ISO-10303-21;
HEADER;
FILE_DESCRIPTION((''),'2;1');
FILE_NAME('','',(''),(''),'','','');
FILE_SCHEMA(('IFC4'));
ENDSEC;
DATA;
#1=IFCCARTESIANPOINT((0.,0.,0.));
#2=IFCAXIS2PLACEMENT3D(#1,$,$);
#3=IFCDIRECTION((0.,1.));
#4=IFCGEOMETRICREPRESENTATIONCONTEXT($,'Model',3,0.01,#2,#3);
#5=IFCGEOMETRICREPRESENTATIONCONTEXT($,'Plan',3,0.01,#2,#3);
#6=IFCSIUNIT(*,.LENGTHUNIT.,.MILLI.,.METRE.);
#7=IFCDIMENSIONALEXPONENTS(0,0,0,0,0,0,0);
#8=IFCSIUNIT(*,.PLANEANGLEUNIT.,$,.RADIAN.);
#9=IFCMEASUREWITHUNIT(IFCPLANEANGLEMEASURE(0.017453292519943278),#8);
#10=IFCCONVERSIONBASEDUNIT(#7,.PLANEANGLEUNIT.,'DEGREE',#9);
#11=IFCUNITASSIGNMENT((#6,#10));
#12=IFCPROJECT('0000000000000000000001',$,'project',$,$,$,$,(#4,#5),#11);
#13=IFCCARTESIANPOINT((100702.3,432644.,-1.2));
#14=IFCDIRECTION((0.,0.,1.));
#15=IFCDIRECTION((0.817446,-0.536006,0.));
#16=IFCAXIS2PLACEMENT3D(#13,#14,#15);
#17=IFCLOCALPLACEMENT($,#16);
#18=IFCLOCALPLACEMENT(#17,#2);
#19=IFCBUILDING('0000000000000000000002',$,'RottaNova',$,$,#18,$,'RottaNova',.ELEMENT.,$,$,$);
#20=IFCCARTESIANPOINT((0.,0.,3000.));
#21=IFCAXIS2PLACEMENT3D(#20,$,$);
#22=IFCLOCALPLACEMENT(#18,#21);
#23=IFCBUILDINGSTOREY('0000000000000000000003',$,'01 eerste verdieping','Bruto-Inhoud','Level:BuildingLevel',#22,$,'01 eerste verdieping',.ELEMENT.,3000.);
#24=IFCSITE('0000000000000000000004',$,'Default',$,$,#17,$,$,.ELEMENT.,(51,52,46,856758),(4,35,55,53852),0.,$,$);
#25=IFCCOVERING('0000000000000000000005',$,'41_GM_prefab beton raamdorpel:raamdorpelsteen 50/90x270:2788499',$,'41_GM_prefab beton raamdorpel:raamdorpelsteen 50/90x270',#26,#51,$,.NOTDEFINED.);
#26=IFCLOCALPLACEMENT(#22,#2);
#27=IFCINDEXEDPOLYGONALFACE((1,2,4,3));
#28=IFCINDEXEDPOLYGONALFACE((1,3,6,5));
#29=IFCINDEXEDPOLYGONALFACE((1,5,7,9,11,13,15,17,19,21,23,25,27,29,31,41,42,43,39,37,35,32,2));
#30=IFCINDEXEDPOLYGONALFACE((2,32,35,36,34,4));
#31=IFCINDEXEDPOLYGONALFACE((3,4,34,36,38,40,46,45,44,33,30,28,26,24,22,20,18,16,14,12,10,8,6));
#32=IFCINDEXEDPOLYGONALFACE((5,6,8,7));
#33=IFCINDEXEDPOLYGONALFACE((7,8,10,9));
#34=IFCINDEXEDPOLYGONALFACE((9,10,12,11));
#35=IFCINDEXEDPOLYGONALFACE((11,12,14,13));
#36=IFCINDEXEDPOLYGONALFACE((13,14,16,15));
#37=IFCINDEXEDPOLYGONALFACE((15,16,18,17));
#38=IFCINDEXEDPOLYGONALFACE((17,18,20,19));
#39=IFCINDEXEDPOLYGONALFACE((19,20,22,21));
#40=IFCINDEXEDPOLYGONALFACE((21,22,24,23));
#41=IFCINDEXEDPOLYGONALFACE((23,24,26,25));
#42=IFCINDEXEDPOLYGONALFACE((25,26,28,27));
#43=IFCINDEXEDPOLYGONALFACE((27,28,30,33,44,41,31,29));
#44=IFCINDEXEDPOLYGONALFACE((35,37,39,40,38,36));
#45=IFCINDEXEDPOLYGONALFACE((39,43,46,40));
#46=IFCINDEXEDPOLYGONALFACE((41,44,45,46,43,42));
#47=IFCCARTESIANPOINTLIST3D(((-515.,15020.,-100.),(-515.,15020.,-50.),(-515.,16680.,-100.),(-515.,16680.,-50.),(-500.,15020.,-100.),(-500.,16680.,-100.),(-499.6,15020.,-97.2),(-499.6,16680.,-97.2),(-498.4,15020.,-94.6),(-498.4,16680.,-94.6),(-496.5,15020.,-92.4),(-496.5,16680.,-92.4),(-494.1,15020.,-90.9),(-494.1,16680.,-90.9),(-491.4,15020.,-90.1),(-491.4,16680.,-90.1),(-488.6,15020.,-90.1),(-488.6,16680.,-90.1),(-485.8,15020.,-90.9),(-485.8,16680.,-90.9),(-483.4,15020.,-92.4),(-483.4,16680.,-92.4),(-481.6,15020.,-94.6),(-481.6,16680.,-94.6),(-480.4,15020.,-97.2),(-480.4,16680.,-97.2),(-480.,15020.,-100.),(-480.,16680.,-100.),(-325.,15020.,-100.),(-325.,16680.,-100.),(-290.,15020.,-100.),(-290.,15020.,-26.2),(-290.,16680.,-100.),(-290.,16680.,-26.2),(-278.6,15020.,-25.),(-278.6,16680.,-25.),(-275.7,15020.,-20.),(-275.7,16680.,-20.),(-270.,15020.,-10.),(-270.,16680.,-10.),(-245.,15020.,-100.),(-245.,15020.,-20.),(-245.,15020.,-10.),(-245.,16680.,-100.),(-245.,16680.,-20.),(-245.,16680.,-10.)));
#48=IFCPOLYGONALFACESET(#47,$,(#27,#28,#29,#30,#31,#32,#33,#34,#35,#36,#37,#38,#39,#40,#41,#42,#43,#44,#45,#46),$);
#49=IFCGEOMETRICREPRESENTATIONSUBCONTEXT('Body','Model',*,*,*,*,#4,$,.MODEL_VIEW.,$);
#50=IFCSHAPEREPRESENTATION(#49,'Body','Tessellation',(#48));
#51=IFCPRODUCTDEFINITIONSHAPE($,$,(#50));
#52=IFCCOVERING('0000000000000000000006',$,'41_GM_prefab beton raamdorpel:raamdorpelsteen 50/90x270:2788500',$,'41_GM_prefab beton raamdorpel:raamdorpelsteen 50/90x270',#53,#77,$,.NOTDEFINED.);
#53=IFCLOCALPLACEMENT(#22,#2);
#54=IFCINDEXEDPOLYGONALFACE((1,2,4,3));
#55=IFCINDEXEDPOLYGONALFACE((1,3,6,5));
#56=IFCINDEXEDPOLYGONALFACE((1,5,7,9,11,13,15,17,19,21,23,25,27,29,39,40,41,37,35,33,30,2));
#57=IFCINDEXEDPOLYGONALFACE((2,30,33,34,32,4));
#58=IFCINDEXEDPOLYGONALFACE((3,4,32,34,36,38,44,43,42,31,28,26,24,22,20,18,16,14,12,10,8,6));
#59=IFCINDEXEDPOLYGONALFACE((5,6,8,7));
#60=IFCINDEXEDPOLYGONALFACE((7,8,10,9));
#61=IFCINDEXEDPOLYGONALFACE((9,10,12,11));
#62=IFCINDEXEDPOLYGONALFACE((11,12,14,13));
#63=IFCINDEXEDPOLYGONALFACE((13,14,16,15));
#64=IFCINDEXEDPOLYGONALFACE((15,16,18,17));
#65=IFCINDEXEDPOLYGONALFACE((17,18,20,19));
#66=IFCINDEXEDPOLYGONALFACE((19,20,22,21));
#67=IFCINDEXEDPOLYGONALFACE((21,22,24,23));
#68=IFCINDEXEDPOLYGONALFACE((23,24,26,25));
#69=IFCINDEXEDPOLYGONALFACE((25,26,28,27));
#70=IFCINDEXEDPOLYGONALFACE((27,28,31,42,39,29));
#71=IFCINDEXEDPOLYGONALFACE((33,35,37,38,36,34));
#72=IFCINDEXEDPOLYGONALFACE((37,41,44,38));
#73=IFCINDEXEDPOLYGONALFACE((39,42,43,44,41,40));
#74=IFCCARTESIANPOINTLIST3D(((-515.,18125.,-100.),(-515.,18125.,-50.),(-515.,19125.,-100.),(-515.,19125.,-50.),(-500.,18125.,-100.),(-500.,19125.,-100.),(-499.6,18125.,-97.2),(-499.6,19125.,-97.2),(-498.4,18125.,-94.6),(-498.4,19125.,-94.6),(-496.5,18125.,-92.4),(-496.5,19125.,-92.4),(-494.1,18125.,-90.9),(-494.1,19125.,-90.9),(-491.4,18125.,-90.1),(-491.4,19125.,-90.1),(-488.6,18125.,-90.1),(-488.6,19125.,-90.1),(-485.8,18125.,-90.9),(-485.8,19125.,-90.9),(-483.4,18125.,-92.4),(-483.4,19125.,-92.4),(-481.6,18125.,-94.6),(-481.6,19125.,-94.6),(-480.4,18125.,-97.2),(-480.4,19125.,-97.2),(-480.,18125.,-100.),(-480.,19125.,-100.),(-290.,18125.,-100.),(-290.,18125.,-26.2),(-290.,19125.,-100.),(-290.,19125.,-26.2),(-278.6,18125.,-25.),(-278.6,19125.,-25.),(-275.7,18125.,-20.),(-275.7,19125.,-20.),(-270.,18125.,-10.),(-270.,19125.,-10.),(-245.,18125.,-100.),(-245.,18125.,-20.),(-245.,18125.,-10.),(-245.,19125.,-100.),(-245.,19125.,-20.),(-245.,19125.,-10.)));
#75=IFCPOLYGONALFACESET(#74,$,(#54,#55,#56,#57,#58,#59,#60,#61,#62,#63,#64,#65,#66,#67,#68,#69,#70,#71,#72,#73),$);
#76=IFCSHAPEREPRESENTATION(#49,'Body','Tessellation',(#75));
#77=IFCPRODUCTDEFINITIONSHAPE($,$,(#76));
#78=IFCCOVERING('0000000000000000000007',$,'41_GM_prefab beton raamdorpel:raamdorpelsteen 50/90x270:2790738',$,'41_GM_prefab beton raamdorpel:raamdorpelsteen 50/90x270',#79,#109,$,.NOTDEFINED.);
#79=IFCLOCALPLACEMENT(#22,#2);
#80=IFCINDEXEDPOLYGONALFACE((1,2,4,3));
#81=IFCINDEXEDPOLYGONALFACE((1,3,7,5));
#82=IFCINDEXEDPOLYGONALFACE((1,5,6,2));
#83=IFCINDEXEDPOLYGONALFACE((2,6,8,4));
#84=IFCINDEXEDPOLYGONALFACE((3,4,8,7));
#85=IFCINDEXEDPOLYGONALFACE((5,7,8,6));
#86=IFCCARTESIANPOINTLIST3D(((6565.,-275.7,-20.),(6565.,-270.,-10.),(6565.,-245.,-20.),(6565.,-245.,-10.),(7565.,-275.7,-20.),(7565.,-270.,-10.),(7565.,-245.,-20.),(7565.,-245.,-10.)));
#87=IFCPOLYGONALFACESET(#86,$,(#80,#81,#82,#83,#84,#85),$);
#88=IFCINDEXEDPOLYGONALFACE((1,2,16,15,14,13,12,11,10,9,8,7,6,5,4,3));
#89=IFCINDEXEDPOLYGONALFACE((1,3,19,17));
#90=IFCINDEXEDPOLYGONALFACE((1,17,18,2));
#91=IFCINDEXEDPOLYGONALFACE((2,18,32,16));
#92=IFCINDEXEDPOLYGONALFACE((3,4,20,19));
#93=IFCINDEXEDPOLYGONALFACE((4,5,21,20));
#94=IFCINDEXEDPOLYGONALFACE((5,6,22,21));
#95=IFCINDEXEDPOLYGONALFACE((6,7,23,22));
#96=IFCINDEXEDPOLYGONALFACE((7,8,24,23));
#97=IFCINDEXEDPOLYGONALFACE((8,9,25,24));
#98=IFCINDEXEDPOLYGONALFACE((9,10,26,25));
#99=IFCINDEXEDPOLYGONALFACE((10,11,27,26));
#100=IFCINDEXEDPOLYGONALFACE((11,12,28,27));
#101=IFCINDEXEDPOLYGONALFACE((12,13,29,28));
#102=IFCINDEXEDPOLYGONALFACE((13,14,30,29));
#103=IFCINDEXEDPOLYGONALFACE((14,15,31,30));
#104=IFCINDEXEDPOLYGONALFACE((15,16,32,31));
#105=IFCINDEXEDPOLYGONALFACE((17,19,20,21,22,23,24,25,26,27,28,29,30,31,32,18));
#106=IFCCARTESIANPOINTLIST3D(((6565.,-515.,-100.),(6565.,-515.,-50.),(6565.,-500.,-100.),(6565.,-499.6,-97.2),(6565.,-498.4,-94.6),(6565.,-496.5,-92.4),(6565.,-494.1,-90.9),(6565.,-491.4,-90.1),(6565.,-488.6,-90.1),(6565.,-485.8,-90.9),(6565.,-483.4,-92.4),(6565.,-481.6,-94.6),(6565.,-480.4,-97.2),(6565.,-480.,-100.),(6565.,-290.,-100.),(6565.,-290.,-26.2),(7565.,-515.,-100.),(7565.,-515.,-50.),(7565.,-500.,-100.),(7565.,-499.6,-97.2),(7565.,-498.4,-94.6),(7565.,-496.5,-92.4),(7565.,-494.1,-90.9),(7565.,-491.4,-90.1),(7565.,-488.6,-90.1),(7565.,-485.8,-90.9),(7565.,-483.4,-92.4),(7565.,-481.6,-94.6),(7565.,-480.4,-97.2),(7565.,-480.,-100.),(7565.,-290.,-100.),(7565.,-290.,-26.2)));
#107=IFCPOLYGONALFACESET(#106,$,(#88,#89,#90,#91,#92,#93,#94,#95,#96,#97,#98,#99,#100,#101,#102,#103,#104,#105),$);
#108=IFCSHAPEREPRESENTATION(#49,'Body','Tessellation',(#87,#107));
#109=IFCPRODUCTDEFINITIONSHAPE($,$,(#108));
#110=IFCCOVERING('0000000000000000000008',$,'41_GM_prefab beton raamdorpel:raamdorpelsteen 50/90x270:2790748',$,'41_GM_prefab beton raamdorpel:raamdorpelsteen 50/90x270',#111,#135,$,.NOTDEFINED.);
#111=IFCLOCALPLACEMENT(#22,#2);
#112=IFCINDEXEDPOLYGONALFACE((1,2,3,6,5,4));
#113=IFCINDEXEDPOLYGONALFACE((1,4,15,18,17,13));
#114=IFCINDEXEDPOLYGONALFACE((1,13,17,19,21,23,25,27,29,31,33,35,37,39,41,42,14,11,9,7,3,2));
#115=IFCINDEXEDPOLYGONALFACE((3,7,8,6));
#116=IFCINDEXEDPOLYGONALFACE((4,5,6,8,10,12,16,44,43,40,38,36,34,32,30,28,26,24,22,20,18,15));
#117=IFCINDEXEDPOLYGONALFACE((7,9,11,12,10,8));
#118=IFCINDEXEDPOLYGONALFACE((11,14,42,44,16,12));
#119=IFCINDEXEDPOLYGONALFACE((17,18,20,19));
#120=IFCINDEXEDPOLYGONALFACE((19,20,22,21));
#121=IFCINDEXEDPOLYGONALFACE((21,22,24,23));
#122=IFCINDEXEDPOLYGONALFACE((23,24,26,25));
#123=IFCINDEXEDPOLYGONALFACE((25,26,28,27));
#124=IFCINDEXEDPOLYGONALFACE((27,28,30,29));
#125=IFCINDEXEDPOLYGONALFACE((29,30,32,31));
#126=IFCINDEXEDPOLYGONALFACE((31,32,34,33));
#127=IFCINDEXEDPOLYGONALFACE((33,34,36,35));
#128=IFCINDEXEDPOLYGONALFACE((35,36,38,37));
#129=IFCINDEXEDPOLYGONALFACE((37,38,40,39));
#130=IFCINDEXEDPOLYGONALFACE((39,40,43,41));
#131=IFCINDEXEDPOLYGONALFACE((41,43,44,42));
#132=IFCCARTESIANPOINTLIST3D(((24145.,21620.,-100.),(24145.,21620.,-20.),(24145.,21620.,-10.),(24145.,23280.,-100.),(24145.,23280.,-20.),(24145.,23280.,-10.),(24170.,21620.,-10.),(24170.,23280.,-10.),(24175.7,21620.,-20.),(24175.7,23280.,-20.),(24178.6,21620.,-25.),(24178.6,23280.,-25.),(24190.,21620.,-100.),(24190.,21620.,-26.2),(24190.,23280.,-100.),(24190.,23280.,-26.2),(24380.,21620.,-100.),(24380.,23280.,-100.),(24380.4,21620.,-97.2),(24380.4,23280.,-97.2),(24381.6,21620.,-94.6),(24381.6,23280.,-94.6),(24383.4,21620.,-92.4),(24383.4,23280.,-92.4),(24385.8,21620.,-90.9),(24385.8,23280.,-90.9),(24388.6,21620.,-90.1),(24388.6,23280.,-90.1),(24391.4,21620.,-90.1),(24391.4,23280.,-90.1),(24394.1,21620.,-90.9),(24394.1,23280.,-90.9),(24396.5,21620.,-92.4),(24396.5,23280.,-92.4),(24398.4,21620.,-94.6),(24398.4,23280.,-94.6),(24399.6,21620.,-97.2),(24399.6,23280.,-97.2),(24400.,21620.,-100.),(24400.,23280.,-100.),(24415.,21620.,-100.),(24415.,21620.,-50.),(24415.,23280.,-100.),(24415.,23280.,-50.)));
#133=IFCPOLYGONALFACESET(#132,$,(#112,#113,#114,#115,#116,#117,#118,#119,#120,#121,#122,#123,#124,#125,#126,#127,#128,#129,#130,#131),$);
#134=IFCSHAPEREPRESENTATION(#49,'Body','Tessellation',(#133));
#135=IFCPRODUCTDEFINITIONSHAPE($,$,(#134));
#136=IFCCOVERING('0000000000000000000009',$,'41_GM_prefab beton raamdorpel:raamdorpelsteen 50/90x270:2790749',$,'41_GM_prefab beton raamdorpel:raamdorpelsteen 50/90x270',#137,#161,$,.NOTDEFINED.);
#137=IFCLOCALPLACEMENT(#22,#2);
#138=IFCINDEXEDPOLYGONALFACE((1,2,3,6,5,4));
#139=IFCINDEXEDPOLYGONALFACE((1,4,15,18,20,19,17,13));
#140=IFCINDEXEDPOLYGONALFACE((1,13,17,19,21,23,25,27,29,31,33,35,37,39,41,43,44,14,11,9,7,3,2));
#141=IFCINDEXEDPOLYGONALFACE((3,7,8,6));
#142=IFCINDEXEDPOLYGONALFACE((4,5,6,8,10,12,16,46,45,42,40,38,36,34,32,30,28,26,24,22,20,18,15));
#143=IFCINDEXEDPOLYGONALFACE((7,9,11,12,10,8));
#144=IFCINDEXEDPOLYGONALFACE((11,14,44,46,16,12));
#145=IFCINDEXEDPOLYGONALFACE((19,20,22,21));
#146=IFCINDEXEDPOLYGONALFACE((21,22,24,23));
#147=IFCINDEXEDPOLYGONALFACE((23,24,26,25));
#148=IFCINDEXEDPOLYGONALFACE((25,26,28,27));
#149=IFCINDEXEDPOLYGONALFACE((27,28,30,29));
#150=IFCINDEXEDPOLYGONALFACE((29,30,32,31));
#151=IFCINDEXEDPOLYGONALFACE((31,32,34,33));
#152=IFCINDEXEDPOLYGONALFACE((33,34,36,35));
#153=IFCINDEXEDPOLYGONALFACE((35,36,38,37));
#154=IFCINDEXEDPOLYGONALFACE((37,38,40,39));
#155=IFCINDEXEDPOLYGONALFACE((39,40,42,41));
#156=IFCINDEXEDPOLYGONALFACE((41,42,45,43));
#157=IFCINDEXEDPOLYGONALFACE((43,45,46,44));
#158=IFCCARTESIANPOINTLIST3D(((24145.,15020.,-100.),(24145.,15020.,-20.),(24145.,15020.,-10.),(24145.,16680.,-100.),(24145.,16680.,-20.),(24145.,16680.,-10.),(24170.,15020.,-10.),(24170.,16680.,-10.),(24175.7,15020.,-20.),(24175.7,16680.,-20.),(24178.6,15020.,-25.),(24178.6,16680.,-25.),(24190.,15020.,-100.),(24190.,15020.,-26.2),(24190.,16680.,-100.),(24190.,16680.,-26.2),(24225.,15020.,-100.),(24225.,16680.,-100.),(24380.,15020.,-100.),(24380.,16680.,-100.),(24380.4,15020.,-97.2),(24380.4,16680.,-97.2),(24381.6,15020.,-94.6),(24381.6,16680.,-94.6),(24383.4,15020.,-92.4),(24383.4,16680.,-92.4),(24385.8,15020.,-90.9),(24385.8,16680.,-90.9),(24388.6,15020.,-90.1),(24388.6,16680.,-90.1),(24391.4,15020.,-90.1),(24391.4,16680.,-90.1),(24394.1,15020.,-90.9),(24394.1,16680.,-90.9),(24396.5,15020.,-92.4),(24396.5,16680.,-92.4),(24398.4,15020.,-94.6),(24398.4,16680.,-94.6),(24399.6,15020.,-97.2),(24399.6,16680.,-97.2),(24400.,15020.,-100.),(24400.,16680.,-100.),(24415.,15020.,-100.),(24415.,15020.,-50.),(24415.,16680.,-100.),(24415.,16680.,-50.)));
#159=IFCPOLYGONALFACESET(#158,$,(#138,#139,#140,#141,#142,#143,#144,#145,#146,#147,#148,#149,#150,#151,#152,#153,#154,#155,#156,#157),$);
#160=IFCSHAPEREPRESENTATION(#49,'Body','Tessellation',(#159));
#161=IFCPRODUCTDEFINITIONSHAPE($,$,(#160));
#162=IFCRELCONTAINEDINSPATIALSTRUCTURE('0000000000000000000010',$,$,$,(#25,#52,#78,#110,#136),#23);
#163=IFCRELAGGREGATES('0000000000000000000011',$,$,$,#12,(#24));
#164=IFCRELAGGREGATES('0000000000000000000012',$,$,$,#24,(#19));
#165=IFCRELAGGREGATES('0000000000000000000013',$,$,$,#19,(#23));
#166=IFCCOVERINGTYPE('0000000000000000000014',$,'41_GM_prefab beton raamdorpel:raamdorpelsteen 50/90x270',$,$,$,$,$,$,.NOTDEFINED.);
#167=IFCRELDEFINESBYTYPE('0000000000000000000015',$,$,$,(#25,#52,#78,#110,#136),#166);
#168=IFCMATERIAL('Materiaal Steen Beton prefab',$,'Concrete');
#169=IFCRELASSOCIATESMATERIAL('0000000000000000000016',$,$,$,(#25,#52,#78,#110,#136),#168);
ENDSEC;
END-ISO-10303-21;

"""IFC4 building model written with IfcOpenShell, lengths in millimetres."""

from ifc_helpers import new_model, entity, si_unit, converted_unit, direction, frame, origin, place, context, subcontext, project, spatial, line, arc, indexed_curve, outline, extrude, material, type_object, element, save


model = new_model("IFC4")

# Units and contexts
model_context = context("Model", 3, precision=0.01, world=origin(), true_north=direction((0.0, 1.0)))
plan_context = context("Plan", 3, precision=0.01, world=origin(), true_north=direction((0.0, 1.0)))
body_context = subcontext(model_context, "Body", "Model", "MODEL_VIEW")
ifc_project = project(units=[si_unit("LENGTHUNIT", "METRE", prefix="MILLI"), converted_unit("PLANEANGLEUNIT", "DEGREE", entity("IfcPlaneAngleMeasure", 0.017453292519943278), si_unit("PLANEANGLEUNIT", "RADIAN"), dimensions=[0, 0, 0, 0, 0, 0, 0])], contexts=[model_context, plan_context])

# Site, building, storey
site_placement = place(None, frame((100702.3, 432644.0, -1.2), z_axis=(0.0, 0.0, 1.0), x_axis=(0.817446, -0.536006, 0.0)))
site = spatial("IfcSite", under=ifc_project, at=site_placement, Name="Default", CompositionType="ELEMENT", RefLatitude=(51, 52, 46, 856758), RefLongitude=(4, 35, 55, 53852), RefElevation=0.0)
building_placement = place(site_placement, origin())
building = spatial("IfcBuilding", under=site, at=building_placement, Name="RottaNova", LongName="RottaNova", CompositionType="ELEMENT")
storey_placement = place(building_placement, frame((0.0, 0.0, 3000.0)))
storey = spatial("IfcBuildingStorey", under=building, at=storey_placement, Name="01 eerste verdieping", Description="Bruto-Inhoud", ObjectType="Level:BuildingLevel", LongName="01 eerste verdieping", CompositionType="ELEMENT", Elevation=3000.0)

# Coverings
ifc_material_1 = material(Name="Materiaal Steen Beton prefab", Category="Concrete")
covering_type_1 = type_object("IfcCoveringType", Name="41_GM_prefab beton raamdorpel:raamdorpelsteen 50/90x270", PredefinedType="NOTDEFINED")
covering_1_placement = place(storey_placement, origin())
element("IfcCovering", 1, at=covering_1_placement, inside=storey, type_object=covering_type_1, material=ifc_material_1, Name="41_GM_prefab beton raamdorpel:raamdorpelsteen 50/90x270:2788499", ObjectType="41_GM_prefab beton raamdorpel:raamdorpelsteen 50/90x270", PredefinedType="NOTDEFINED", context=body_context, shape_type="SweptSolid", body=[
    extrude(outline(indexed_curve([(74.2, -48.6), (99.2, -48.6), (99.2, -38.6), (99.2, 41.4), (54.2, 41.4), (19.2, 41.4), (-135.8, 41.4), (-145.8, 31.4), (-155.8, 41.4), (-170.8, 41.4), (-170.8, -8.6), (54.2, -32.4), (65.5, -33.6), (68.4, -38.6)], segments=[line(1, 2, 3, 4, 5, 6, 7), arc(7, 8, 9), line(9, 10, 11, 12, 13, 14, 1)], self_intersect=False)), frame((-344.2, 15020.0, -58.6), z_axis=(0.0, 1.0, 0.0), x_axis=(1.0, 0.0, 0.0)), (0.0, 0.0, 1.0), 1660.0),
])
covering_2_placement = place(storey_placement, origin())
element("IfcCovering", 2, at=covering_2_placement, inside=storey, type_object=covering_type_1, material=ifc_material_1, Name="41_GM_prefab beton raamdorpel:raamdorpelsteen 50/90x270:2788500", ObjectType="41_GM_prefab beton raamdorpel:raamdorpelsteen 50/90x270", PredefinedType="NOTDEFINED", context=body_context, shape_type="SweptSolid", body=[
    extrude(outline(indexed_curve([(75.8, -45.1), (100.8, -45.1), (100.8, -35.1), (100.8, 44.9), (55.8, 44.9), (-134.2, 44.9), (-144.2, 34.9), (-154.2, 44.9), (-169.2, 44.9), (-169.2, -5.1), (55.8, -28.9), (67.1, -30.1), (70.0, -35.1)], segments=[line(1, 2, 3, 4, 5, 6), arc(6, 7, 8), line(8, 9, 10, 11, 12, 13, 1)], self_intersect=False)), frame((-345.8, 18125.0, -55.1), z_axis=(0.0, 1.0, 0.0), x_axis=(1.0, 0.0, 0.0)), (0.0, 0.0, 1.0), 1000.0),
])
covering_3_placement = place(storey_placement, origin())
element("IfcCovering", 3, at=covering_3_placement, inside=storey, type_object=covering_type_1, material=ifc_material_1, Name="41_GM_prefab beton raamdorpel:raamdorpelsteen 50/90x270:2790738", ObjectType="41_GM_prefab beton raamdorpel:raamdorpelsteen 50/90x270", PredefinedType="NOTDEFINED", context=body_context, shape_type="SweptSolid", body=[
    extrude(outline(indexed_curve([(1.2, -12.1), (12.7, -12.1), (-2.6, 14.6), (-11.3, 9.6), (1.2, -12.1)], self_intersect=False)), frame((6565.0, -258.9, -15.0), z_axis=(1.0, 0.0, 0.0), x_axis=(0.0, -0.5, -0.866025)), (0.0, 0.0, 1.0), 1000.0),
    extrude(outline(indexed_curve([(-48.3, -20.6), (141.7, -20.6), (141.7, 53.2), (-83.3, 29.4), (-83.3, -20.6), (-68.3, -20.6), (-58.3, -10.6)], segments=[line(1, 2, 3, 4, 5, 6), arc(6, 7, 1)], self_intersect=False)), frame((6565.0, -431.7, -79.4), z_axis=(1.0, 0.0, 0.0), x_axis=(0.0, 1.0, 0.0)), (0.0, 0.0, 1.0), 1000.0),
])
covering_4_placement = place(storey_placement, origin())
element("IfcCovering", 4, at=covering_4_placement, inside=storey, type_object=covering_type_1, material=ifc_material_1, Name="41_GM_prefab beton raamdorpel:raamdorpelsteen 50/90x270:2790748", ObjectType="41_GM_prefab beton raamdorpel:raamdorpelsteen 50/90x270", PredefinedType="NOTDEFINED", context=body_context, shape_type="SweptSolid", body=[
    extrude(outline(indexed_curve([(-77.0, -43.1), (-89.5, -64.7), (-80.8, -69.7), (-11.5, -109.7), (11.0, -70.7), (106.0, 93.8), (102.3, 107.5), (116.0, 111.1), (123.5, 124.1), (80.2, 149.1), (-52.9, -33.8), (-59.6, -43.1), (-65.4, -43.1)], segments=[line(1, 2, 3, 4, 5, 6), arc(6, 7, 8), line(8, 9, 10, 11, 12, 13, 1)], self_intersect=False)), frame((24245.8, 21620.0, -55.1), z_axis=(0.0, -1.0, 0.0), x_axis=(0.5, 0.0, -0.866025)), (0.0, 0.0, -1.0), 1660.0),
])
covering_5_placement = place(storey_placement, origin())
element("IfcCovering", 5, at=covering_5_placement, inside=storey, type_object=covering_type_1, material=ifc_material_1, Name="41_GM_prefab beton raamdorpel:raamdorpelsteen 50/90x270:2790749", ObjectType="41_GM_prefab beton raamdorpel:raamdorpelsteen 50/90x270", PredefinedType="NOTDEFINED", context=body_context, shape_type="SweptSolid", body=[
    extrude(outline(indexed_curve([(-79.1, -40.0), (-91.6, -61.6), (-83.0, -66.6), (-13.7, -106.6), (8.8, -67.6), (26.3, -37.3), (103.8, 96.9), (100.1, 110.6), (113.8, 114.2), (121.3, 127.2), (78.0, 152.2), (-55.1, -30.7), (-61.8, -40.0), (-67.6, -40.0)], segments=[line(1, 2, 3, 4, 5, 6, 7), arc(7, 8, 9), line(9, 10, 11, 12, 13, 14, 1)], self_intersect=False)), frame((24244.2, 15020.0, -58.6), z_axis=(0.0, -1.0, 0.0), x_axis=(0.5, 0.0, -0.866025)), (0.0, 0.0, -1.0), 1660.0),
])

save(model, "model.ifc")
